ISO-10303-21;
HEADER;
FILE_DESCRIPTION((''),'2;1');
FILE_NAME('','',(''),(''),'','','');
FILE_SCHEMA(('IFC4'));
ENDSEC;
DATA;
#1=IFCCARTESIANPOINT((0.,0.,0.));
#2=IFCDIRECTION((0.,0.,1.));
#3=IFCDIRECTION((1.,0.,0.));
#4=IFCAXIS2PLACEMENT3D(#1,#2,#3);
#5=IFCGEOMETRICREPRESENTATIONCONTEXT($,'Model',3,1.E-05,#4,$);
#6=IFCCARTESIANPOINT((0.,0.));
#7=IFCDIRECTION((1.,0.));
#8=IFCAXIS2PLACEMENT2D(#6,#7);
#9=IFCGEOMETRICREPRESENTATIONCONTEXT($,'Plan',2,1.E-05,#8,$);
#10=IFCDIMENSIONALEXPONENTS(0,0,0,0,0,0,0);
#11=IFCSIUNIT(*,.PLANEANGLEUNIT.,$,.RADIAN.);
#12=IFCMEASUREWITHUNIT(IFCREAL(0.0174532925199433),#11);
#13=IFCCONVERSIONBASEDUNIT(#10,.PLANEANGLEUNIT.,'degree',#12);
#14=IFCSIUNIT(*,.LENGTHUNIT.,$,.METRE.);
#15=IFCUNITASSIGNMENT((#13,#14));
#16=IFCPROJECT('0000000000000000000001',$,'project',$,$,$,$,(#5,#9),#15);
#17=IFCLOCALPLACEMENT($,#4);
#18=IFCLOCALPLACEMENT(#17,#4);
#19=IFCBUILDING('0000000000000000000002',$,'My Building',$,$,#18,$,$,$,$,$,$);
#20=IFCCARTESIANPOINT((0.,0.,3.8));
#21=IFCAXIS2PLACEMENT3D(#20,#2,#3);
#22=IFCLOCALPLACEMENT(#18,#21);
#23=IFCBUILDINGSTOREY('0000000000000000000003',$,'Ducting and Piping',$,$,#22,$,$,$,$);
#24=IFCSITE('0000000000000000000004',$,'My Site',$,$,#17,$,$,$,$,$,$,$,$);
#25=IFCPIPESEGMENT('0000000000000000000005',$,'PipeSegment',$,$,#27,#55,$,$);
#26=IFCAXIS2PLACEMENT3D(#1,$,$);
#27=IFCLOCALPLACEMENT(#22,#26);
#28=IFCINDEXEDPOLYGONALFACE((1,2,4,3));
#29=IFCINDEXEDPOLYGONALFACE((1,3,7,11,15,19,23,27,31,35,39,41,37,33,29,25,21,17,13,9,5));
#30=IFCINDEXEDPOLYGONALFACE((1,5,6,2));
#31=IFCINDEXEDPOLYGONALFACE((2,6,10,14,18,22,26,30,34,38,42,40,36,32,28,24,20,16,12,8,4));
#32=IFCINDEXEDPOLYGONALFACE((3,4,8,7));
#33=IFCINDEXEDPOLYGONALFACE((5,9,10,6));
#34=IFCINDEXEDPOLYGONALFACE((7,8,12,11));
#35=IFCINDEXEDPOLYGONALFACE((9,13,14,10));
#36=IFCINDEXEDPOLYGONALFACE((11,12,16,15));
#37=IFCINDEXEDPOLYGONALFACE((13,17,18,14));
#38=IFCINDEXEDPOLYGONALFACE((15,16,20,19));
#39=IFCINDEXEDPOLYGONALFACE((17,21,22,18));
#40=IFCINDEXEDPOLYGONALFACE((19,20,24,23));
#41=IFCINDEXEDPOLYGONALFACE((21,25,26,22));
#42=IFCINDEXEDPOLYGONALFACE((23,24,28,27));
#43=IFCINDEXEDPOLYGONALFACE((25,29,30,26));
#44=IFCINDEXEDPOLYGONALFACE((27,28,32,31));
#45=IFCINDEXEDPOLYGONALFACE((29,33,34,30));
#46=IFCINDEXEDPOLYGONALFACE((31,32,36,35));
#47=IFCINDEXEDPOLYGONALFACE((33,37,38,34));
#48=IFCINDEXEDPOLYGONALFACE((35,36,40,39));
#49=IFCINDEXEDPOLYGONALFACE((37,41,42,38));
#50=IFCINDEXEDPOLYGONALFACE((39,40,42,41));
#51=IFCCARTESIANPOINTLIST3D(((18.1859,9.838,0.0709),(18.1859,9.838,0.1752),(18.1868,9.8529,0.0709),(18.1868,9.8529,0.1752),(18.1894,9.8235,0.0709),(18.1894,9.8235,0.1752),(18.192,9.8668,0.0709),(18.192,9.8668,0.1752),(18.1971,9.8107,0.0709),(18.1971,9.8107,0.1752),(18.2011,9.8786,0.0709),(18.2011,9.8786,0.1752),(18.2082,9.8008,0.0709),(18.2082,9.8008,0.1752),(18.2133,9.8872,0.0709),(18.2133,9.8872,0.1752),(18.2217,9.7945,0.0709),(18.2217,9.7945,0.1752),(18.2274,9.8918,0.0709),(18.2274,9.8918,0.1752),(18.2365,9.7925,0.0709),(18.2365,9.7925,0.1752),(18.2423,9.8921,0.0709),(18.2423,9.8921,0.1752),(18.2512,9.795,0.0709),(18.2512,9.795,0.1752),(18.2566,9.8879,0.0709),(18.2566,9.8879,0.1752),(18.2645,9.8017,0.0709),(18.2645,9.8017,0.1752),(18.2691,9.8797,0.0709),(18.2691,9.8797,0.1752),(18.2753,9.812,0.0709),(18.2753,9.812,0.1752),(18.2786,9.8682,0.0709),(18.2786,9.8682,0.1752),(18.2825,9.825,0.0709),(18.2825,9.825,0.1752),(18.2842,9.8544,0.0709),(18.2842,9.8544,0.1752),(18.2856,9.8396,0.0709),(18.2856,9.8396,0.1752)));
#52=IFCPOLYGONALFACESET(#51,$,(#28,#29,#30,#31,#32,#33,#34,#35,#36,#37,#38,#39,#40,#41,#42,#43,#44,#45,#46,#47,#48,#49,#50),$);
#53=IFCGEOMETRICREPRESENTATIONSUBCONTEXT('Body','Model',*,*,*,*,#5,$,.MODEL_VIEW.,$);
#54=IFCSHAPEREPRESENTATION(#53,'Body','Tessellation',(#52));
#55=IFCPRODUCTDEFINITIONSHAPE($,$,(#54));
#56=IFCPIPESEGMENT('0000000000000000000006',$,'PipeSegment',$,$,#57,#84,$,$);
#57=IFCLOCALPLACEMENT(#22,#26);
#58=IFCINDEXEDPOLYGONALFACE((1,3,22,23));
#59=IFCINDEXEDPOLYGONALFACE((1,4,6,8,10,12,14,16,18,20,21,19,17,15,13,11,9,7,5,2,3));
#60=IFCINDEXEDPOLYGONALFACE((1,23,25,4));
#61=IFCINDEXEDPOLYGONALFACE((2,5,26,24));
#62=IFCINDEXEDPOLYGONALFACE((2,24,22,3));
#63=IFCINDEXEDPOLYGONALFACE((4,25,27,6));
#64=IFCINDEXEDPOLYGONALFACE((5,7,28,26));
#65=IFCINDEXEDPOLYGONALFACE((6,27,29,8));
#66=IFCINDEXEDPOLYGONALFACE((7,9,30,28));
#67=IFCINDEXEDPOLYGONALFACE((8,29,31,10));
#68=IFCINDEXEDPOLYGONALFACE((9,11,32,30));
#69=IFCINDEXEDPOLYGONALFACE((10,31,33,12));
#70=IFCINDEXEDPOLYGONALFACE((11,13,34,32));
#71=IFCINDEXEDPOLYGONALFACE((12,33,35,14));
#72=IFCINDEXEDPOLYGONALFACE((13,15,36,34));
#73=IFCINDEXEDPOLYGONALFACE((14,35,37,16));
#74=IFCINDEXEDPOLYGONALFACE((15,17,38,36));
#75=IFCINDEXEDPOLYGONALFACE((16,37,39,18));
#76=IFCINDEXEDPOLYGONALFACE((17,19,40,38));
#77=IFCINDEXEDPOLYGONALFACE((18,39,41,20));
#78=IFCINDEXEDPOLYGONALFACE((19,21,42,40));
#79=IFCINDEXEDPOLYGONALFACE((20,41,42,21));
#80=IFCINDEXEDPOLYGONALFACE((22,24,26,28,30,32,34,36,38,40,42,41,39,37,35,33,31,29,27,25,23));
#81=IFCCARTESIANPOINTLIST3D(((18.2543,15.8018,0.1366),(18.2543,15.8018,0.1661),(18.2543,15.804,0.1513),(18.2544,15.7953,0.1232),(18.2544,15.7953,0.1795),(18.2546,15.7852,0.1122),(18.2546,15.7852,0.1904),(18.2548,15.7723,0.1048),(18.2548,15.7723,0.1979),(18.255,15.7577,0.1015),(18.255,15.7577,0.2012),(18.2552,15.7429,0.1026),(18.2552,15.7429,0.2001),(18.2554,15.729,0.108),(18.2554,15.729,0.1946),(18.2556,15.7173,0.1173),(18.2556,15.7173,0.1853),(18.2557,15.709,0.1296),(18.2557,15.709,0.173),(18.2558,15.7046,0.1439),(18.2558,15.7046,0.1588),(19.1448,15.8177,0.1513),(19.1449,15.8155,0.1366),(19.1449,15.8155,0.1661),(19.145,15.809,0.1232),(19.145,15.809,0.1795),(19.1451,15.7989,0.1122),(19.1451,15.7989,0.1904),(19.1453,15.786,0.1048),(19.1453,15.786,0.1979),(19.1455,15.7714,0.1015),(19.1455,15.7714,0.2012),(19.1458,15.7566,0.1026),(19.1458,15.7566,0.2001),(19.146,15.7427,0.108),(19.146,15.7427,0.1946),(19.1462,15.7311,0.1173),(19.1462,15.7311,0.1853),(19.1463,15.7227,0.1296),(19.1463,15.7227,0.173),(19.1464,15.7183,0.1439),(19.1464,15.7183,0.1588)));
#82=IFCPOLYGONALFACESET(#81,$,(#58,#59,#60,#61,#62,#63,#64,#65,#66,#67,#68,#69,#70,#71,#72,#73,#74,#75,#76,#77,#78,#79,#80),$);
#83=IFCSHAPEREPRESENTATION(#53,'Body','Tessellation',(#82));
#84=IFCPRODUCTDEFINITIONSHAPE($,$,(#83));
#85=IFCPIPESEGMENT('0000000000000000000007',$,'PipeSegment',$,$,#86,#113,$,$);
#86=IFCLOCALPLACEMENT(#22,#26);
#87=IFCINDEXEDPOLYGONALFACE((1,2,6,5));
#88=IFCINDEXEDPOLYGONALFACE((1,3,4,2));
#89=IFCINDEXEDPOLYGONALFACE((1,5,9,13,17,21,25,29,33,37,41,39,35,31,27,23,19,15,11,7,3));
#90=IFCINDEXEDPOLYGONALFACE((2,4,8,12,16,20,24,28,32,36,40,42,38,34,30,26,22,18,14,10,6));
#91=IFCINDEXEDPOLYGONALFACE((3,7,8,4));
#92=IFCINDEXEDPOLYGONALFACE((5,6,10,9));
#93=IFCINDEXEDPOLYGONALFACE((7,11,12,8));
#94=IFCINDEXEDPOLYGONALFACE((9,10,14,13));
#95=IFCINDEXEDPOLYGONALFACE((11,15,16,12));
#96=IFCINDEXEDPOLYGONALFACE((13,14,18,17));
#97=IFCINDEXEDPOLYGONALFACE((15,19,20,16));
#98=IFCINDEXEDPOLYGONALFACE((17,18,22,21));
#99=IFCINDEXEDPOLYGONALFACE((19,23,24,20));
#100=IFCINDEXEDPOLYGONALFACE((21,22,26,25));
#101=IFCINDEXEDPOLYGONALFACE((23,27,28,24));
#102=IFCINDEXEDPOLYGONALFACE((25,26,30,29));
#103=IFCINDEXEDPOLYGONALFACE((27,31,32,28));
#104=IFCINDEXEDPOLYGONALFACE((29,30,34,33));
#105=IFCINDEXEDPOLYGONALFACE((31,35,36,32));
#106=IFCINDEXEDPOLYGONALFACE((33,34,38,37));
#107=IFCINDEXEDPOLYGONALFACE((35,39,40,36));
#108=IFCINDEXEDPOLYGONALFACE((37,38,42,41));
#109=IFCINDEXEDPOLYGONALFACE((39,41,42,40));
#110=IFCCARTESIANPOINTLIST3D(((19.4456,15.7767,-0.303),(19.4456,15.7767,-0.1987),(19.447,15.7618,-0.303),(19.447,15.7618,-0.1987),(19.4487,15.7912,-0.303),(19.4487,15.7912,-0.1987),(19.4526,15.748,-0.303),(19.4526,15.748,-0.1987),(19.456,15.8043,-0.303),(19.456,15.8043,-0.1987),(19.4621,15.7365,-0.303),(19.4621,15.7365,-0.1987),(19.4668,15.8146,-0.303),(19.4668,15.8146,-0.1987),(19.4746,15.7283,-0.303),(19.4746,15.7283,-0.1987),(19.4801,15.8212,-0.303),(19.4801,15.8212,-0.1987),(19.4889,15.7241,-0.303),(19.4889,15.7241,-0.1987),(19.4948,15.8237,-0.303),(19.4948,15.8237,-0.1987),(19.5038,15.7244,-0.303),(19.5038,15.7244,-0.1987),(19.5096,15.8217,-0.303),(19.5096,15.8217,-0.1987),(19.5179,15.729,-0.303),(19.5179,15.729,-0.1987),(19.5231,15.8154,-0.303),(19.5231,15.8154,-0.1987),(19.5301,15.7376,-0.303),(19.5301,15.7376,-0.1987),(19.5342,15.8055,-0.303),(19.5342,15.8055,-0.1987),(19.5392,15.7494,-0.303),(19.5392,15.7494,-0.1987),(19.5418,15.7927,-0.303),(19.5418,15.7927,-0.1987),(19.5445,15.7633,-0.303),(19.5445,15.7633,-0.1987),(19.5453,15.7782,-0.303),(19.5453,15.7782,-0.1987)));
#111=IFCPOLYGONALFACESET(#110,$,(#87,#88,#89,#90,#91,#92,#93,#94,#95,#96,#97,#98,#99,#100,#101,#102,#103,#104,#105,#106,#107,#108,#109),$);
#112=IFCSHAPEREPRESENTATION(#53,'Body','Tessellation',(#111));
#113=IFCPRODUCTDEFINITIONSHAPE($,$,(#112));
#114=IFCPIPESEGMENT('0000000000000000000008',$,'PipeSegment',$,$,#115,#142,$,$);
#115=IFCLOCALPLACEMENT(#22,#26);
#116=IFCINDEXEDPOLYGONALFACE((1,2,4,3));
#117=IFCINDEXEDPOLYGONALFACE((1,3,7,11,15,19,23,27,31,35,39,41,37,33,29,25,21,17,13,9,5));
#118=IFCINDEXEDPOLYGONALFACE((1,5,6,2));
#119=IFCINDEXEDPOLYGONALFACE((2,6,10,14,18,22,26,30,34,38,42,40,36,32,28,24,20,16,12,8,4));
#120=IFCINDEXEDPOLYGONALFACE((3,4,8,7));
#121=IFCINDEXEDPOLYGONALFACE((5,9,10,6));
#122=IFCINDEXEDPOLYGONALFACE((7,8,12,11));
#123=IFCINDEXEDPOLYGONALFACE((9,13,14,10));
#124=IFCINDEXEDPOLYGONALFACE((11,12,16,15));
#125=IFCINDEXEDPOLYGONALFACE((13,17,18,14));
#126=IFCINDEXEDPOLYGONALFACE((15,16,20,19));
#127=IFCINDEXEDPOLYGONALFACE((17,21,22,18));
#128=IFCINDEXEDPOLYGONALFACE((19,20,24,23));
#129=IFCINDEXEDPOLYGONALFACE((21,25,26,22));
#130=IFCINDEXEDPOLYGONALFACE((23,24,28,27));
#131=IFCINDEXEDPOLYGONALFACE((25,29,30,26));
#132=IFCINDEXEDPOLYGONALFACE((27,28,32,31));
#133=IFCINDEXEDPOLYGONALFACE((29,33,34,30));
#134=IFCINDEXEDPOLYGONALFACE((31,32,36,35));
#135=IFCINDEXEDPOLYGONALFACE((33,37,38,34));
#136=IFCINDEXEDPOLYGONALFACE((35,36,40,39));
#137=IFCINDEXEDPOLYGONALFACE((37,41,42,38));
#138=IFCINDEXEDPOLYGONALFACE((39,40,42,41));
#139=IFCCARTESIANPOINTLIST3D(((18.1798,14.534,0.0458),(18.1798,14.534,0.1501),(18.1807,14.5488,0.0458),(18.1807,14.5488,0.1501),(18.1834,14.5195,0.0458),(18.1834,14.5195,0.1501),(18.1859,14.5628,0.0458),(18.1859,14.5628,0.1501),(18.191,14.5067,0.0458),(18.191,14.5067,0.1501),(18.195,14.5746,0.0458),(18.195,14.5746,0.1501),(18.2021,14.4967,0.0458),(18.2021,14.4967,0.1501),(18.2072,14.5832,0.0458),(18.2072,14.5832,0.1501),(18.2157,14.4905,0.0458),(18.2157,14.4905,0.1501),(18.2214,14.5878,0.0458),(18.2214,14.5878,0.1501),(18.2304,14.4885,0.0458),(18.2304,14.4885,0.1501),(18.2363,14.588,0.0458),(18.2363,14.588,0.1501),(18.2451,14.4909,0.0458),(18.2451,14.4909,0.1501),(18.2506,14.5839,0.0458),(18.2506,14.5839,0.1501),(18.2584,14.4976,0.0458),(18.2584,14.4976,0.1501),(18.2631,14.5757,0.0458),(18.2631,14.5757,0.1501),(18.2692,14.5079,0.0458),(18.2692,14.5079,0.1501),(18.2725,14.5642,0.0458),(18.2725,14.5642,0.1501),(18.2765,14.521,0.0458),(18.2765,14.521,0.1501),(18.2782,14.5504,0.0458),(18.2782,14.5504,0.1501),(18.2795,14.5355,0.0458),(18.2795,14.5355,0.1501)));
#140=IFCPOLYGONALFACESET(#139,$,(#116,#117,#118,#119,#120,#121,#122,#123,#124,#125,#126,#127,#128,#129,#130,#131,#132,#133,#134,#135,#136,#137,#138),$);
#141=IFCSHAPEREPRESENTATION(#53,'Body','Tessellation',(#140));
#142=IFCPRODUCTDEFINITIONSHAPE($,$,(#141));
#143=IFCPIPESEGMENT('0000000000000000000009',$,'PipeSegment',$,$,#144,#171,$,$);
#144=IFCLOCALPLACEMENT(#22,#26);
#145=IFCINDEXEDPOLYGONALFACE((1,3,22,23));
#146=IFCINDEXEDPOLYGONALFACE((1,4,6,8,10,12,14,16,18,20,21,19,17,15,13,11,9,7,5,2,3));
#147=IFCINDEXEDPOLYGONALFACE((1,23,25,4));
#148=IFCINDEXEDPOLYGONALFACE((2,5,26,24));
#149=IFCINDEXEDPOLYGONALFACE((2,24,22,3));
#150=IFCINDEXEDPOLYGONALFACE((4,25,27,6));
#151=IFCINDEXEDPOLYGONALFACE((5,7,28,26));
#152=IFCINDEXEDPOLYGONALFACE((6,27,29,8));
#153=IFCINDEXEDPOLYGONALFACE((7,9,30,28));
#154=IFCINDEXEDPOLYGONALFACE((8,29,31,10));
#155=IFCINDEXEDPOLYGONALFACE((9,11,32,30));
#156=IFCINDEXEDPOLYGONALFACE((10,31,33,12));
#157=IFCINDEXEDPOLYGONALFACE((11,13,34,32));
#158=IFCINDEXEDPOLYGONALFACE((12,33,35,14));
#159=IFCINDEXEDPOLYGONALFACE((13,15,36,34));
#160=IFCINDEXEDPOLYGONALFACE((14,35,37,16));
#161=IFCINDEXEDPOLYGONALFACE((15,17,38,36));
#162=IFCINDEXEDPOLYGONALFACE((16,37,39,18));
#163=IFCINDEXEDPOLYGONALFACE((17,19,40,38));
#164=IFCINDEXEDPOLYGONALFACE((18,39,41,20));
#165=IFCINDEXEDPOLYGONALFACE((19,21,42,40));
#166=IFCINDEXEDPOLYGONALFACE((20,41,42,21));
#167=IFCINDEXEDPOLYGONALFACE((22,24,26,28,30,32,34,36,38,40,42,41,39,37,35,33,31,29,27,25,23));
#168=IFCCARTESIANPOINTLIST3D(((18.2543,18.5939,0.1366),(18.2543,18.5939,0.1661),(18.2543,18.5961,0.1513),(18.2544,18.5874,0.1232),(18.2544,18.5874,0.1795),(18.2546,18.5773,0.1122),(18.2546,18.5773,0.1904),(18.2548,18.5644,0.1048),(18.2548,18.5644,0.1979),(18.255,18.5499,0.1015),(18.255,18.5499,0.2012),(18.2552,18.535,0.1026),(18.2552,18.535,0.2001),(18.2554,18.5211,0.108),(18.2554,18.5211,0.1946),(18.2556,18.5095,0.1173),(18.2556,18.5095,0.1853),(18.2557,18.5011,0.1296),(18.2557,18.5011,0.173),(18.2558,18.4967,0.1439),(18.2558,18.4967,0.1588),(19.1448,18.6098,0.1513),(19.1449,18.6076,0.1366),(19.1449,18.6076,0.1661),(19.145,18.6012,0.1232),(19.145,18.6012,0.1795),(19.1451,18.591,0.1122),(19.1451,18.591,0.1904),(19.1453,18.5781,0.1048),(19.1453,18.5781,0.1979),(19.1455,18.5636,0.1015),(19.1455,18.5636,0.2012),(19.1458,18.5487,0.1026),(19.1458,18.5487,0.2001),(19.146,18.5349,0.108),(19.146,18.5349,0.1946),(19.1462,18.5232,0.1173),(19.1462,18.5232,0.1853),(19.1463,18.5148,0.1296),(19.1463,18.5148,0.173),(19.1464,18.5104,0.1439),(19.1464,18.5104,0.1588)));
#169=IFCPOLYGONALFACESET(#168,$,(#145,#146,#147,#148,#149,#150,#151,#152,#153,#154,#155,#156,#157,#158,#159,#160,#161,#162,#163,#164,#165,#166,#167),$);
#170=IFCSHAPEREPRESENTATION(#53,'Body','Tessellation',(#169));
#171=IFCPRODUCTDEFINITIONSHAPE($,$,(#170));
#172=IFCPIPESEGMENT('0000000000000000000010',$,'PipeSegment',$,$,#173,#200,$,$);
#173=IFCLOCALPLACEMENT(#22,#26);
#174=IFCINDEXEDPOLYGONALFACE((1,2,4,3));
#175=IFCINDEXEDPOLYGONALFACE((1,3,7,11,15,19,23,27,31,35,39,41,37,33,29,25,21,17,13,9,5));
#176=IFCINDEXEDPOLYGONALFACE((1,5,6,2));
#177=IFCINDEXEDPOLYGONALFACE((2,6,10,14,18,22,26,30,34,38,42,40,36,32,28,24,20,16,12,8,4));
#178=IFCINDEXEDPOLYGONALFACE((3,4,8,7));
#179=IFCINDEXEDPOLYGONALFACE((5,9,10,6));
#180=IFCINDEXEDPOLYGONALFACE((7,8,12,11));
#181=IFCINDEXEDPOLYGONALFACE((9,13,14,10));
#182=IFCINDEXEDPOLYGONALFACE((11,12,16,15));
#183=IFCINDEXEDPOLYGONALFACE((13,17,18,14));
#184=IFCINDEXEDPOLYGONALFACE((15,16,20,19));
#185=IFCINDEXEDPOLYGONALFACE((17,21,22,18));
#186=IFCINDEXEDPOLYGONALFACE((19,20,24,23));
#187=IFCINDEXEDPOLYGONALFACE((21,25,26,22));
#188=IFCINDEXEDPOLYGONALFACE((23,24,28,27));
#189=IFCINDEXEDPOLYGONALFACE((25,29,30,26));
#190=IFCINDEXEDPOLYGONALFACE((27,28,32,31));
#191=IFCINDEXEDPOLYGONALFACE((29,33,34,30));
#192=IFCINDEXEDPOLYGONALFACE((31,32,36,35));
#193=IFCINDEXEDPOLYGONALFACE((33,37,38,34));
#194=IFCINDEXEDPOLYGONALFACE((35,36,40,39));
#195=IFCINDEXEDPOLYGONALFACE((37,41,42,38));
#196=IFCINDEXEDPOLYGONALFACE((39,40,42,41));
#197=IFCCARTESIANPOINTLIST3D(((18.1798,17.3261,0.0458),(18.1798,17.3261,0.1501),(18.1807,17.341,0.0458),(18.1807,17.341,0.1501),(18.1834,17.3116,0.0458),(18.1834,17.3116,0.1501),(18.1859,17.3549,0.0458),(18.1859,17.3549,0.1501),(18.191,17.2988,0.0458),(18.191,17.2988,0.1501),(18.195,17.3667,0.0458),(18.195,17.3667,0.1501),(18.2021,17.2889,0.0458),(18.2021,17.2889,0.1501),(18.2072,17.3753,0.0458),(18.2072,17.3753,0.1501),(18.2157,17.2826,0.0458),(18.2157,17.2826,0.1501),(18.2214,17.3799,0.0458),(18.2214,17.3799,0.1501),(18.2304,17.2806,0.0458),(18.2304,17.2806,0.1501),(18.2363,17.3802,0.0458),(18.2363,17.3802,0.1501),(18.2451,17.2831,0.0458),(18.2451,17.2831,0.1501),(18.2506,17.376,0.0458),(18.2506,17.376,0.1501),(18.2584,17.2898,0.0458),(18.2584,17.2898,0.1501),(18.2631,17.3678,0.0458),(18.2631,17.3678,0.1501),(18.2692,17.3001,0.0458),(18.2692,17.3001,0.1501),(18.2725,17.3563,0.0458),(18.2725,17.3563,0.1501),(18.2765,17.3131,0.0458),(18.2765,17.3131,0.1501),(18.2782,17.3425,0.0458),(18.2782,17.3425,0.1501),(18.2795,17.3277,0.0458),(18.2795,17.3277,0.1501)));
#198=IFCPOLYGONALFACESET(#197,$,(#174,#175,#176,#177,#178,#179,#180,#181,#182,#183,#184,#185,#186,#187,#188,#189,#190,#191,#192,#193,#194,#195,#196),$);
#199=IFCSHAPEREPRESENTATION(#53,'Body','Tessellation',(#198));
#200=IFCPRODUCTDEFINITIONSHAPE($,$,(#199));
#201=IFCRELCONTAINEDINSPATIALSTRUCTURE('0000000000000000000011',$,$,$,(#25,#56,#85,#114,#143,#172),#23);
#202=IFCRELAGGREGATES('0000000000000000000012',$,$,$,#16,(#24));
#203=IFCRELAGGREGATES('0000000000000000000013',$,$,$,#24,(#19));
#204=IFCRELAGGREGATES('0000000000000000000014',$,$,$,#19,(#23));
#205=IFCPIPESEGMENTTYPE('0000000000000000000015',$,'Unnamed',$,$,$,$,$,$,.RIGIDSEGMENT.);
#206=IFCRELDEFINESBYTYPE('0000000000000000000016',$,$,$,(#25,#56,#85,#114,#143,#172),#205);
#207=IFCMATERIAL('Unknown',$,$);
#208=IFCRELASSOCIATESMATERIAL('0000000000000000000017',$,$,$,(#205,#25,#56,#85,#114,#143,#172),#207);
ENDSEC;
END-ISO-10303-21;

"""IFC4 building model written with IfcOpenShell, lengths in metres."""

from ifc_helpers import new_model, entity, si_unit, converted_unit, frame, origin_with_axes, origin_2d_with_axis, place, context, subcontext, project, spatial, circle, extrude, material, material_profile, profile_set, profile_usage, type_object, element, save


model = new_model("IFC4")

# Units and contexts
model_context = context("Model", 3, precision=1e-05, world=origin_with_axes())
plan_context = context("Plan", 2, precision=1e-05, world=origin_2d_with_axis())
body_context = subcontext(model_context, "Body", "Model", "MODEL_VIEW")
ifc_project = project(units=[converted_unit("PLANEANGLEUNIT", "degree", entity("IfcReal", 0.0174532925199433), si_unit("PLANEANGLEUNIT", "RADIAN"), dimensions=[0, 0, 0, 0, 0, 0, 0]), si_unit("LENGTHUNIT", "METRE")], contexts=[model_context, plan_context])

# Site, building, storey
site_placement = place(None, origin_with_axes())
site = spatial("IfcSite", under=ifc_project, at=site_placement, Name="My Site")
building_placement = place(site_placement, origin_with_axes())
building = spatial("IfcBuilding", under=site, at=building_placement, Name="My Building")
storey_placement = place(building_placement, frame((0.0, 0.0, 3.8), z_axis=(0.0, 0.0, 1.0), x_axis=(1.0, 0.0, 0.0)))
storey = spatial("IfcBuildingStorey", under=building, at=storey_placement, Name="Ducting and Piping")

# Pipe segments
ifc_material = material(Name="Unknown")
ifc_material_profile_1 = material_profile(ifc_material, circle(Radius=0.05))
ifc_profile_set_1 = profile_set([ifc_material_profile_1])
pipe_segment_type = type_object("IfcPipeSegmentType", Name="Unnamed", PredefinedType="RIGIDSEGMENT", material=ifc_profile_set_1)
ifc_profile_usage_1 = profile_usage(ifc_profile_set_1, cardinal=5)
pipe_segment_1_placement = place(storey_placement, frame((18.2357, 9.8425, 0.0709), z_axis=(0.0, 0.0, 1.0), x_axis=(0.015928, -0.999873, 0.0)))
element("IfcPipeSegment", 1, at=pipe_segment_1_placement, inside=storey, type_object=pipe_segment_type, material=ifc_profile_usage_1, Name="PipeSegment", context=body_context, shape_type="SweptSolid", body=[
    extrude(circle(Radius=0.05), origin_with_axes(), (0.0, 0.0, 1.0), 0.1043),
])
ifc_profile_usage_2 = profile_usage(ifc_profile_set_1, cardinal=5)
pipe_segment_2_placement = place(storey_placement, frame((18.2551, 15.754, 0.1513), z_axis=(0.999882, 0.015389, 0.0), x_axis=(-0.015389, 0.999882, 0.0)))
element("IfcPipeSegment", 2, at=pipe_segment_2_placement, inside=storey, type_object=pipe_segment_type, material=ifc_profile_usage_2, Name="PipeSegment", context=body_context, shape_type="SweptSolid", body=[
    extrude(circle(Radius=0.05), origin_with_axes(), (0.0, 0.0, 1.0), 0.8907),
])
ifc_profile_usage_3 = profile_usage(ifc_profile_set_1, cardinal=5)
pipe_segment_3_placement = place(storey_placement, frame((19.4956, 15.7737, -0.303), z_axis=(0.0, 0.0, 1.0), x_axis=(-0.015371, 0.999882, 0.0)))
element("IfcPipeSegment", 3, at=pipe_segment_3_placement, inside=storey, type_object=pipe_segment_type, material=ifc_profile_usage_3, Name="PipeSegment", context=body_context, shape_type="SweptSolid", body=[
    extrude(circle(Radius=0.05), origin_with_axes(), (0.0, 0.0, 1.0), 0.1043),
])
ifc_profile_usage_4 = profile_usage(ifc_profile_set_1, cardinal=5)
pipe_segment_4_placement = place(storey_placement, frame((18.2296, 14.5385, 0.0458), z_axis=(0.0, 0.0, 1.0), x_axis=(0.015928, -0.999873, 0.0)))
element("IfcPipeSegment", 4, at=pipe_segment_4_placement, inside=storey, type_object=pipe_segment_type, material=ifc_profile_usage_4, Name="PipeSegment", context=body_context, shape_type="SweptSolid", body=[
    extrude(circle(Radius=0.05), origin_with_axes(), (0.0, 0.0, 1.0), 0.1043),
])
ifc_profile_usage_5 = profile_usage(ifc_profile_set_1, cardinal=5)
pipe_segment_5_placement = place(storey_placement, frame((18.2551, 18.5461, 0.1513), z_axis=(0.999882, 0.015389, 0.0), x_axis=(-0.015389, 0.999882, 0.0)))
element("IfcPipeSegment", 5, at=pipe_segment_5_placement, inside=storey, type_object=pipe_segment_type, material=ifc_profile_usage_5, Name="PipeSegment", context=body_context, shape_type="SweptSolid", body=[
    extrude(circle(Radius=0.05), origin_with_axes(), (0.0, 0.0, 1.0), 0.8907),
])
ifc_profile_usage_6 = profile_usage(ifc_profile_set_1, cardinal=5)
pipe_segment_6_placement = place(storey_placement, frame((18.2296, 17.3306, 0.0458), z_axis=(0.0, 0.0, 1.0), x_axis=(0.015928, -0.999873, 0.0)))
element("IfcPipeSegment", 6, at=pipe_segment_6_placement, inside=storey, type_object=pipe_segment_type, material=ifc_profile_usage_6, Name="PipeSegment", context=body_context, shape_type="SweptSolid", body=[
    extrude(circle(Radius=0.05), origin_with_axes(), (0.0, 0.0, 1.0), 0.1043),
])

save(model, "model.ifc")
